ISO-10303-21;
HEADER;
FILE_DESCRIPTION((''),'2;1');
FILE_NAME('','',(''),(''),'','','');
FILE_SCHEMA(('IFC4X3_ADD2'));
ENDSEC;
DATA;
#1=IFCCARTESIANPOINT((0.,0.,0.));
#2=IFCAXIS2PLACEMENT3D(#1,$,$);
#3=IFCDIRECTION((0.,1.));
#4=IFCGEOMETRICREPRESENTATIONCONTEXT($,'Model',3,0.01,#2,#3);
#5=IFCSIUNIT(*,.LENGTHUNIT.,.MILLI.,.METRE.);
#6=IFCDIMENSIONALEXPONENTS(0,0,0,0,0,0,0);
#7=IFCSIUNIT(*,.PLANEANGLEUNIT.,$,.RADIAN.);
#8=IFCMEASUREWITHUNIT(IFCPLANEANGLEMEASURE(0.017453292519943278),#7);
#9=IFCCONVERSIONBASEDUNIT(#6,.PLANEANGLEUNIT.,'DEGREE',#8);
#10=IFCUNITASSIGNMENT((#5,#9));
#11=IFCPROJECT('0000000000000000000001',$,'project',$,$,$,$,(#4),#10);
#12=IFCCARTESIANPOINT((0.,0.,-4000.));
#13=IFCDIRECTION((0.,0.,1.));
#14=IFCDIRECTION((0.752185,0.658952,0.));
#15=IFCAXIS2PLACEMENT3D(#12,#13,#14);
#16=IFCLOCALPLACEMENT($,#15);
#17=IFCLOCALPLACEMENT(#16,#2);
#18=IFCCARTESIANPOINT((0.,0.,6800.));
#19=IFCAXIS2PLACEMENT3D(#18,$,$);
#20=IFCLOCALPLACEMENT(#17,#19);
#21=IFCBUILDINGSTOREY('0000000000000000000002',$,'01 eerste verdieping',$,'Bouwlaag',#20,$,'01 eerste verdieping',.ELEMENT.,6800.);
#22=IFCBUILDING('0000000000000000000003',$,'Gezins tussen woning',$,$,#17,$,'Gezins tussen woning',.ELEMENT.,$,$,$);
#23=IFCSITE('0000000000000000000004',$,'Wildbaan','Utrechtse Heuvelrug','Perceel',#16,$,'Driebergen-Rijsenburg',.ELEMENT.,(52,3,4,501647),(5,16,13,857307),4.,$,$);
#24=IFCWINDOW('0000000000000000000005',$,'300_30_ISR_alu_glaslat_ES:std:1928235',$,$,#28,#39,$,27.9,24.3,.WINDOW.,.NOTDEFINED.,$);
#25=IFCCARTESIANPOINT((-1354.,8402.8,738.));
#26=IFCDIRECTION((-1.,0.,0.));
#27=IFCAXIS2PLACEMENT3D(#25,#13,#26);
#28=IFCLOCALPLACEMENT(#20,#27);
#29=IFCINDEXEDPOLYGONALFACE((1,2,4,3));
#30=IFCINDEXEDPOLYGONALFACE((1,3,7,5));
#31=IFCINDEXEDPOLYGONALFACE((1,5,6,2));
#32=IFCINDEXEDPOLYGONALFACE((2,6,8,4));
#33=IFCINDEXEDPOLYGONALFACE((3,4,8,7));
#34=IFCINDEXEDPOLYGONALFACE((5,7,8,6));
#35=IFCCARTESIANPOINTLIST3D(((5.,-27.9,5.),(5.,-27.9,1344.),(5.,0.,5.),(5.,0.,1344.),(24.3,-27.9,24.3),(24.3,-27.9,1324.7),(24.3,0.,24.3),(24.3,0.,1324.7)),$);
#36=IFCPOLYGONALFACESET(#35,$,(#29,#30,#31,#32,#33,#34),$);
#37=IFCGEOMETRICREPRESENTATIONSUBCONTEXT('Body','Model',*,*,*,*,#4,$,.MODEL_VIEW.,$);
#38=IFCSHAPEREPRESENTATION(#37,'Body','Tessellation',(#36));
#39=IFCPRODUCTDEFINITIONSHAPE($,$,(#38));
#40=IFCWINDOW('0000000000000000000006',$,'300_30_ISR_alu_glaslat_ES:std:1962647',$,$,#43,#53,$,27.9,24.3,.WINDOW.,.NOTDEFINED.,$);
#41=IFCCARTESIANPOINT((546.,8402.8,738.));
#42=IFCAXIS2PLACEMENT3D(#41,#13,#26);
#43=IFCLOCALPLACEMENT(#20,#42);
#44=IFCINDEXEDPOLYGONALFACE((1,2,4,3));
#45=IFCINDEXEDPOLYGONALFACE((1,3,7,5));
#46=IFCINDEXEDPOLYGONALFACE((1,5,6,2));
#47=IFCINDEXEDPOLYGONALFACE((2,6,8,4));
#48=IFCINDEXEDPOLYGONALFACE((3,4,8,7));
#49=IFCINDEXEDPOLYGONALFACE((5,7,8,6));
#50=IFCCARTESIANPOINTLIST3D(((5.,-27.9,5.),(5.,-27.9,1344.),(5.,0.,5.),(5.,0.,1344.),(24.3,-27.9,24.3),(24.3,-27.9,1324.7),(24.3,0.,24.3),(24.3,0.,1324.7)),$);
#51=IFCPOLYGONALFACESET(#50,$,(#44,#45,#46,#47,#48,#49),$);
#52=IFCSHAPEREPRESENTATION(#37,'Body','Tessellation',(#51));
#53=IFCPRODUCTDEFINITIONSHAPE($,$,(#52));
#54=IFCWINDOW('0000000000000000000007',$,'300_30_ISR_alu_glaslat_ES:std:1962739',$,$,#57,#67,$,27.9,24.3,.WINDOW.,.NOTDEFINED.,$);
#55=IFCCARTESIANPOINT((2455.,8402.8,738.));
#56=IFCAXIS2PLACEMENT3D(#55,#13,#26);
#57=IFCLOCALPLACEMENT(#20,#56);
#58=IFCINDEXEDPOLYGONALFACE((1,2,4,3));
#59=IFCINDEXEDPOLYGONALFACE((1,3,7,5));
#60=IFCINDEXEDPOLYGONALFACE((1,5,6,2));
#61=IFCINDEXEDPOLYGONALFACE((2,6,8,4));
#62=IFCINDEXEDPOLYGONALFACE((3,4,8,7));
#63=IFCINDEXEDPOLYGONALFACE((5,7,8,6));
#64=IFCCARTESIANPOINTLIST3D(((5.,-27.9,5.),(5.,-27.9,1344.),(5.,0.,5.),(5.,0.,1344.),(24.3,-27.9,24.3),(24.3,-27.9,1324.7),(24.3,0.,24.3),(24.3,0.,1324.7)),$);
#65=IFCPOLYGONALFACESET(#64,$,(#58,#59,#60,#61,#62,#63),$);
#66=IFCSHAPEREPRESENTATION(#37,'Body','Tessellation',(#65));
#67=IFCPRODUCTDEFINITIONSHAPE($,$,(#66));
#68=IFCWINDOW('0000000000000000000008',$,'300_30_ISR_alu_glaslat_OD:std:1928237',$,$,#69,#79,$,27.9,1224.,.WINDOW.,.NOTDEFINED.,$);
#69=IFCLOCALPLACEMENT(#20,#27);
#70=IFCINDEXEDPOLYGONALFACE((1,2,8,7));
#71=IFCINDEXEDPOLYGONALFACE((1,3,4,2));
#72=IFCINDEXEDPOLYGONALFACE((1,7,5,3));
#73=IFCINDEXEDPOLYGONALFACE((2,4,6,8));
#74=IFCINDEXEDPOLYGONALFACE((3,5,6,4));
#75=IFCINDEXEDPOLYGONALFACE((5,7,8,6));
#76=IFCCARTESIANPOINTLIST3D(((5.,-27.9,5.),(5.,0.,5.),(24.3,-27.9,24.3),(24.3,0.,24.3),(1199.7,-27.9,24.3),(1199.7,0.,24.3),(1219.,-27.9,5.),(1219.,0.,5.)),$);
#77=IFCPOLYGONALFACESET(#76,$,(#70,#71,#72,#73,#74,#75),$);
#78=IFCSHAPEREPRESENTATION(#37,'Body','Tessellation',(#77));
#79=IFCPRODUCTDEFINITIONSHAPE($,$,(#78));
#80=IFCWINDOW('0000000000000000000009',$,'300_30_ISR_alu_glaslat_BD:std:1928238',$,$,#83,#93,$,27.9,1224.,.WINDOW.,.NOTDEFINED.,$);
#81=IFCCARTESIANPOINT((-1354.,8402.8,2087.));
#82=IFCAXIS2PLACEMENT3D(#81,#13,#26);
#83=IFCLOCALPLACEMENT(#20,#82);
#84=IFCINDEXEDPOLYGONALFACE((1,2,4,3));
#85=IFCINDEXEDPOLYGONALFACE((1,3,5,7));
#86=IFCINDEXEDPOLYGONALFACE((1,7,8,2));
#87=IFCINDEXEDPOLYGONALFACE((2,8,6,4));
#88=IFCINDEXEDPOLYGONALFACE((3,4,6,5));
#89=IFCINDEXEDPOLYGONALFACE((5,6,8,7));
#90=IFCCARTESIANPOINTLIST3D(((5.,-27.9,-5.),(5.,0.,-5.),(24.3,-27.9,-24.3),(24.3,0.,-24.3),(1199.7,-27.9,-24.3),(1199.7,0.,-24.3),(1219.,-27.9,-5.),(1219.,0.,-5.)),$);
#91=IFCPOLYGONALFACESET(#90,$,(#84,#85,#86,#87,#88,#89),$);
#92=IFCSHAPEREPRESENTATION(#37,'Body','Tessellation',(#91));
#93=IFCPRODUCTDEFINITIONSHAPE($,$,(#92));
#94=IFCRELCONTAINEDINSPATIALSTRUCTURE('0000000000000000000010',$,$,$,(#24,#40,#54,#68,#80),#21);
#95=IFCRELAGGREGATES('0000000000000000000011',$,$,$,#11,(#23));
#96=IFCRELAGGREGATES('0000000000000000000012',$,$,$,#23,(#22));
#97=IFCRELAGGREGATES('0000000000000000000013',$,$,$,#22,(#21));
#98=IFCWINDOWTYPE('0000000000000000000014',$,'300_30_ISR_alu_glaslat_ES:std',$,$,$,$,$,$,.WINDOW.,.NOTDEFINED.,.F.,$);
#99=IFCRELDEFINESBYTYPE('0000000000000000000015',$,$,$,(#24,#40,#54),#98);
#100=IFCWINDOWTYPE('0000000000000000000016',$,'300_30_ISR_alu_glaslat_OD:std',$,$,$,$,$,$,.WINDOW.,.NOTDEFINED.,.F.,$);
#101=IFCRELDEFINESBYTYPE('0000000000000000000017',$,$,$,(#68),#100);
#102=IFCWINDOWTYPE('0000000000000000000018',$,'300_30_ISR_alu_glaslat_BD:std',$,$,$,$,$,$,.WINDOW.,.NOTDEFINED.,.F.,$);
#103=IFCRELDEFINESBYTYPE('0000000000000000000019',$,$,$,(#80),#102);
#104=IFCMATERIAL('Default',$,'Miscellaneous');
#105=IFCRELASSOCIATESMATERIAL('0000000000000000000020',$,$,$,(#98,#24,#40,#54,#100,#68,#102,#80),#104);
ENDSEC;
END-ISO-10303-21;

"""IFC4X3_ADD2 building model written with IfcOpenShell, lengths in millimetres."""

from ifc_helpers import new_model, entity, si_unit, converted_unit, direction, frame, origin, place, context, subcontext, project, spatial, polyline, outline, extrude, source, transform, mapped, material, type_object, type_shapes, element, save


model = new_model("IFC4X3_ADD2")

# Units and contexts
model_context = context("Model", 3, precision=0.01, world=origin(), true_north=direction((0.0, 1.0)))
body_context = subcontext(model_context, "Body", "Model", "MODEL_VIEW")
ifc_project = project(units=[si_unit("LENGTHUNIT", "METRE", prefix="MILLI"), converted_unit("PLANEANGLEUNIT", "DEGREE", entity("IfcPlaneAngleMeasure", 0.017453292519943278), si_unit("PLANEANGLEUNIT", "RADIAN"), dimensions=[0, 0, 0, 0, 0, 0, 0])], contexts=[model_context])

# Site, building, storey
site_placement = place(None, frame((0.0, 0.0, -4000.0), z_axis=(0.0, 0.0, 1.0), x_axis=(0.752185, 0.658952, 0.0)))
site = spatial("IfcSite", under=ifc_project, at=site_placement, Name="Wildbaan", Description="Utrechtse Heuvelrug", ObjectType="Perceel", LongName="Driebergen-Rijsenburg", CompositionType="ELEMENT", RefLatitude=(52, 3, 4, 501647), RefLongitude=(5, 16, 13, 857307), RefElevation=4.0)
building_placement = place(site_placement, origin())
building = spatial("IfcBuilding", under=site, at=building_placement, Name="Gezins tussen woning", LongName="Gezins tussen woning", CompositionType="ELEMENT")
storey_placement = place(building_placement, frame((0.0, 0.0, 6800.0)))
storey = spatial("IfcBuildingStorey", under=building, at=storey_placement, Name="01 eerste verdieping", ObjectType="Bouwlaag", LongName="01 eerste verdieping", CompositionType="ELEMENT", Elevation=6800.0)

# Windows
ifc_material_1 = material(Name="Default", Category="Miscellaneous")
window_type_1 = type_object("IfcWindowType", Name="300_30_ISR_alu_glaslat_ES:std", ParameterTakesPrecedence=False, PartitioningType="NOTDEFINED", PredefinedType="WINDOW", material=ifc_material_1)
shared_shape_1 = source(origin(), body_context, "Body", "SweptSolid", [
    extrude(outline(polyline([(-650.2, -9.6), (650.2, -9.6), (669.5, 9.6), (-669.5, 9.6), (-650.2, -9.6)])), frame((14.6, -27.9, 674.5), z_axis=(0.0, 1.0, 0.0), x_axis=(0.0, 0.0, -1.0)), (0.0, 0.0, 1.0), 27.9),
])
type_shapes(window_type_1, [shared_shape_1])
for number, where, z_axis, x_axis, name in (
    (1, (-1354.0, 8402.8, 738.0), (0.0, 0.0, 1.0), (-1.0, 0.0, 0.0), "300_30_ISR_alu_glaslat_ES:std:1928235"),
    (2, (546.0, 8402.8, 738.0), (0.0, 0.0, 1.0), (-1.0, 0.0, 0.0), "300_30_ISR_alu_glaslat_ES:std:1962647"),
    (3, (2455.0, 8402.8, 738.0), (0.0, 0.0, 1.0), (-1.0, 0.0, 0.0), "300_30_ISR_alu_glaslat_ES:std:1962739"),
):
    element("IfcWindow", number, at=place(storey_placement, frame(where, z_axis=z_axis, x_axis=x_axis)), inside=storey, type_object=window_type_1, material=ifc_material_1, Name=name, OverallHeight=27.9, OverallWidth=24.3, PartitioningType="NOTDEFINED", PredefinedType="WINDOW", context=body_context, shape_type="MappedRepresentation", body=[
        mapped(shared_shape_1, transform((0.0, 0.0, 0.0), scale=1.0)),
    ])
window_type_2 = type_object("IfcWindowType", Name="300_30_ISR_alu_glaslat_OD:std", ParameterTakesPrecedence=False, PartitioningType="NOTDEFINED", PredefinedType="WINDOW", material=ifc_material_1)
shared_shape_2 = source(origin(), body_context, "Body", "SweptSolid", [
    extrude(outline(polyline([(-587.7, -9.7), (587.7, -9.7), (607.0, 9.7), (-607.0, 9.6), (-587.7, -9.7)])), frame((612.0, -27.9, 14.6), z_axis=(0.0, 1.0, 0.0), x_axis=(1.0, 0.0, 0.0)), (0.0, 0.0, 1.0), 27.9),
])
type_shapes(window_type_2, [shared_shape_2])
window_1_placement = place(storey_placement, frame((-1354.0, 8402.8, 738.0), z_axis=(0.0, 0.0, 1.0), x_axis=(-1.0, 0.0, 0.0)))
element("IfcWindow", 4, at=window_1_placement, inside=storey, type_object=window_type_2, material=ifc_material_1, Name="300_30_ISR_alu_glaslat_OD:std:1928237", OverallHeight=27.9, OverallWidth=1224.0, PartitioningType="NOTDEFINED", PredefinedType="WINDOW", context=body_context, shape_type="MappedRepresentation", body=[
    mapped(shared_shape_2, transform((0.0, 0.0, 0.0), scale=1.0)),
])
window_type_3 = type_object("IfcWindowType", Name="300_30_ISR_alu_glaslat_BD:std", ParameterTakesPrecedence=False, PartitioningType="NOTDEFINED", PredefinedType="WINDOW", material=ifc_material_1)
shared_shape_3 = source(origin(), body_context, "Body", "SweptSolid", [
    extrude(outline(polyline([(-607.0, -9.6), (607.0, -9.6), (587.7, 9.6), (-587.7, 9.7), (-607.0, -9.6)])), frame((612.0, -27.9, -14.6), z_axis=(0.0, 1.0, 0.0), x_axis=(1.0, 0.0, 0.0)), (0.0, 0.0, 1.0), 27.9),
])
type_shapes(window_type_3, [shared_shape_3])
window_2_placement = place(storey_placement, frame((-1354.0, 8402.8, 2087.0), z_axis=(0.0, 0.0, 1.0), x_axis=(-1.0, 0.0, 0.0)))
element("IfcWindow", 5, at=window_2_placement, inside=storey, type_object=window_type_3, material=ifc_material_1, Name="300_30_ISR_alu_glaslat_BD:std:1928238", OverallHeight=27.9, OverallWidth=1224.0, PartitioningType="NOTDEFINED", PredefinedType="WINDOW", context=body_context, shape_type="MappedRepresentation", body=[
    mapped(shared_shape_3, transform((0.0, 0.0, 0.0), scale=1.0)),
])

save(model, "model.ifc")
